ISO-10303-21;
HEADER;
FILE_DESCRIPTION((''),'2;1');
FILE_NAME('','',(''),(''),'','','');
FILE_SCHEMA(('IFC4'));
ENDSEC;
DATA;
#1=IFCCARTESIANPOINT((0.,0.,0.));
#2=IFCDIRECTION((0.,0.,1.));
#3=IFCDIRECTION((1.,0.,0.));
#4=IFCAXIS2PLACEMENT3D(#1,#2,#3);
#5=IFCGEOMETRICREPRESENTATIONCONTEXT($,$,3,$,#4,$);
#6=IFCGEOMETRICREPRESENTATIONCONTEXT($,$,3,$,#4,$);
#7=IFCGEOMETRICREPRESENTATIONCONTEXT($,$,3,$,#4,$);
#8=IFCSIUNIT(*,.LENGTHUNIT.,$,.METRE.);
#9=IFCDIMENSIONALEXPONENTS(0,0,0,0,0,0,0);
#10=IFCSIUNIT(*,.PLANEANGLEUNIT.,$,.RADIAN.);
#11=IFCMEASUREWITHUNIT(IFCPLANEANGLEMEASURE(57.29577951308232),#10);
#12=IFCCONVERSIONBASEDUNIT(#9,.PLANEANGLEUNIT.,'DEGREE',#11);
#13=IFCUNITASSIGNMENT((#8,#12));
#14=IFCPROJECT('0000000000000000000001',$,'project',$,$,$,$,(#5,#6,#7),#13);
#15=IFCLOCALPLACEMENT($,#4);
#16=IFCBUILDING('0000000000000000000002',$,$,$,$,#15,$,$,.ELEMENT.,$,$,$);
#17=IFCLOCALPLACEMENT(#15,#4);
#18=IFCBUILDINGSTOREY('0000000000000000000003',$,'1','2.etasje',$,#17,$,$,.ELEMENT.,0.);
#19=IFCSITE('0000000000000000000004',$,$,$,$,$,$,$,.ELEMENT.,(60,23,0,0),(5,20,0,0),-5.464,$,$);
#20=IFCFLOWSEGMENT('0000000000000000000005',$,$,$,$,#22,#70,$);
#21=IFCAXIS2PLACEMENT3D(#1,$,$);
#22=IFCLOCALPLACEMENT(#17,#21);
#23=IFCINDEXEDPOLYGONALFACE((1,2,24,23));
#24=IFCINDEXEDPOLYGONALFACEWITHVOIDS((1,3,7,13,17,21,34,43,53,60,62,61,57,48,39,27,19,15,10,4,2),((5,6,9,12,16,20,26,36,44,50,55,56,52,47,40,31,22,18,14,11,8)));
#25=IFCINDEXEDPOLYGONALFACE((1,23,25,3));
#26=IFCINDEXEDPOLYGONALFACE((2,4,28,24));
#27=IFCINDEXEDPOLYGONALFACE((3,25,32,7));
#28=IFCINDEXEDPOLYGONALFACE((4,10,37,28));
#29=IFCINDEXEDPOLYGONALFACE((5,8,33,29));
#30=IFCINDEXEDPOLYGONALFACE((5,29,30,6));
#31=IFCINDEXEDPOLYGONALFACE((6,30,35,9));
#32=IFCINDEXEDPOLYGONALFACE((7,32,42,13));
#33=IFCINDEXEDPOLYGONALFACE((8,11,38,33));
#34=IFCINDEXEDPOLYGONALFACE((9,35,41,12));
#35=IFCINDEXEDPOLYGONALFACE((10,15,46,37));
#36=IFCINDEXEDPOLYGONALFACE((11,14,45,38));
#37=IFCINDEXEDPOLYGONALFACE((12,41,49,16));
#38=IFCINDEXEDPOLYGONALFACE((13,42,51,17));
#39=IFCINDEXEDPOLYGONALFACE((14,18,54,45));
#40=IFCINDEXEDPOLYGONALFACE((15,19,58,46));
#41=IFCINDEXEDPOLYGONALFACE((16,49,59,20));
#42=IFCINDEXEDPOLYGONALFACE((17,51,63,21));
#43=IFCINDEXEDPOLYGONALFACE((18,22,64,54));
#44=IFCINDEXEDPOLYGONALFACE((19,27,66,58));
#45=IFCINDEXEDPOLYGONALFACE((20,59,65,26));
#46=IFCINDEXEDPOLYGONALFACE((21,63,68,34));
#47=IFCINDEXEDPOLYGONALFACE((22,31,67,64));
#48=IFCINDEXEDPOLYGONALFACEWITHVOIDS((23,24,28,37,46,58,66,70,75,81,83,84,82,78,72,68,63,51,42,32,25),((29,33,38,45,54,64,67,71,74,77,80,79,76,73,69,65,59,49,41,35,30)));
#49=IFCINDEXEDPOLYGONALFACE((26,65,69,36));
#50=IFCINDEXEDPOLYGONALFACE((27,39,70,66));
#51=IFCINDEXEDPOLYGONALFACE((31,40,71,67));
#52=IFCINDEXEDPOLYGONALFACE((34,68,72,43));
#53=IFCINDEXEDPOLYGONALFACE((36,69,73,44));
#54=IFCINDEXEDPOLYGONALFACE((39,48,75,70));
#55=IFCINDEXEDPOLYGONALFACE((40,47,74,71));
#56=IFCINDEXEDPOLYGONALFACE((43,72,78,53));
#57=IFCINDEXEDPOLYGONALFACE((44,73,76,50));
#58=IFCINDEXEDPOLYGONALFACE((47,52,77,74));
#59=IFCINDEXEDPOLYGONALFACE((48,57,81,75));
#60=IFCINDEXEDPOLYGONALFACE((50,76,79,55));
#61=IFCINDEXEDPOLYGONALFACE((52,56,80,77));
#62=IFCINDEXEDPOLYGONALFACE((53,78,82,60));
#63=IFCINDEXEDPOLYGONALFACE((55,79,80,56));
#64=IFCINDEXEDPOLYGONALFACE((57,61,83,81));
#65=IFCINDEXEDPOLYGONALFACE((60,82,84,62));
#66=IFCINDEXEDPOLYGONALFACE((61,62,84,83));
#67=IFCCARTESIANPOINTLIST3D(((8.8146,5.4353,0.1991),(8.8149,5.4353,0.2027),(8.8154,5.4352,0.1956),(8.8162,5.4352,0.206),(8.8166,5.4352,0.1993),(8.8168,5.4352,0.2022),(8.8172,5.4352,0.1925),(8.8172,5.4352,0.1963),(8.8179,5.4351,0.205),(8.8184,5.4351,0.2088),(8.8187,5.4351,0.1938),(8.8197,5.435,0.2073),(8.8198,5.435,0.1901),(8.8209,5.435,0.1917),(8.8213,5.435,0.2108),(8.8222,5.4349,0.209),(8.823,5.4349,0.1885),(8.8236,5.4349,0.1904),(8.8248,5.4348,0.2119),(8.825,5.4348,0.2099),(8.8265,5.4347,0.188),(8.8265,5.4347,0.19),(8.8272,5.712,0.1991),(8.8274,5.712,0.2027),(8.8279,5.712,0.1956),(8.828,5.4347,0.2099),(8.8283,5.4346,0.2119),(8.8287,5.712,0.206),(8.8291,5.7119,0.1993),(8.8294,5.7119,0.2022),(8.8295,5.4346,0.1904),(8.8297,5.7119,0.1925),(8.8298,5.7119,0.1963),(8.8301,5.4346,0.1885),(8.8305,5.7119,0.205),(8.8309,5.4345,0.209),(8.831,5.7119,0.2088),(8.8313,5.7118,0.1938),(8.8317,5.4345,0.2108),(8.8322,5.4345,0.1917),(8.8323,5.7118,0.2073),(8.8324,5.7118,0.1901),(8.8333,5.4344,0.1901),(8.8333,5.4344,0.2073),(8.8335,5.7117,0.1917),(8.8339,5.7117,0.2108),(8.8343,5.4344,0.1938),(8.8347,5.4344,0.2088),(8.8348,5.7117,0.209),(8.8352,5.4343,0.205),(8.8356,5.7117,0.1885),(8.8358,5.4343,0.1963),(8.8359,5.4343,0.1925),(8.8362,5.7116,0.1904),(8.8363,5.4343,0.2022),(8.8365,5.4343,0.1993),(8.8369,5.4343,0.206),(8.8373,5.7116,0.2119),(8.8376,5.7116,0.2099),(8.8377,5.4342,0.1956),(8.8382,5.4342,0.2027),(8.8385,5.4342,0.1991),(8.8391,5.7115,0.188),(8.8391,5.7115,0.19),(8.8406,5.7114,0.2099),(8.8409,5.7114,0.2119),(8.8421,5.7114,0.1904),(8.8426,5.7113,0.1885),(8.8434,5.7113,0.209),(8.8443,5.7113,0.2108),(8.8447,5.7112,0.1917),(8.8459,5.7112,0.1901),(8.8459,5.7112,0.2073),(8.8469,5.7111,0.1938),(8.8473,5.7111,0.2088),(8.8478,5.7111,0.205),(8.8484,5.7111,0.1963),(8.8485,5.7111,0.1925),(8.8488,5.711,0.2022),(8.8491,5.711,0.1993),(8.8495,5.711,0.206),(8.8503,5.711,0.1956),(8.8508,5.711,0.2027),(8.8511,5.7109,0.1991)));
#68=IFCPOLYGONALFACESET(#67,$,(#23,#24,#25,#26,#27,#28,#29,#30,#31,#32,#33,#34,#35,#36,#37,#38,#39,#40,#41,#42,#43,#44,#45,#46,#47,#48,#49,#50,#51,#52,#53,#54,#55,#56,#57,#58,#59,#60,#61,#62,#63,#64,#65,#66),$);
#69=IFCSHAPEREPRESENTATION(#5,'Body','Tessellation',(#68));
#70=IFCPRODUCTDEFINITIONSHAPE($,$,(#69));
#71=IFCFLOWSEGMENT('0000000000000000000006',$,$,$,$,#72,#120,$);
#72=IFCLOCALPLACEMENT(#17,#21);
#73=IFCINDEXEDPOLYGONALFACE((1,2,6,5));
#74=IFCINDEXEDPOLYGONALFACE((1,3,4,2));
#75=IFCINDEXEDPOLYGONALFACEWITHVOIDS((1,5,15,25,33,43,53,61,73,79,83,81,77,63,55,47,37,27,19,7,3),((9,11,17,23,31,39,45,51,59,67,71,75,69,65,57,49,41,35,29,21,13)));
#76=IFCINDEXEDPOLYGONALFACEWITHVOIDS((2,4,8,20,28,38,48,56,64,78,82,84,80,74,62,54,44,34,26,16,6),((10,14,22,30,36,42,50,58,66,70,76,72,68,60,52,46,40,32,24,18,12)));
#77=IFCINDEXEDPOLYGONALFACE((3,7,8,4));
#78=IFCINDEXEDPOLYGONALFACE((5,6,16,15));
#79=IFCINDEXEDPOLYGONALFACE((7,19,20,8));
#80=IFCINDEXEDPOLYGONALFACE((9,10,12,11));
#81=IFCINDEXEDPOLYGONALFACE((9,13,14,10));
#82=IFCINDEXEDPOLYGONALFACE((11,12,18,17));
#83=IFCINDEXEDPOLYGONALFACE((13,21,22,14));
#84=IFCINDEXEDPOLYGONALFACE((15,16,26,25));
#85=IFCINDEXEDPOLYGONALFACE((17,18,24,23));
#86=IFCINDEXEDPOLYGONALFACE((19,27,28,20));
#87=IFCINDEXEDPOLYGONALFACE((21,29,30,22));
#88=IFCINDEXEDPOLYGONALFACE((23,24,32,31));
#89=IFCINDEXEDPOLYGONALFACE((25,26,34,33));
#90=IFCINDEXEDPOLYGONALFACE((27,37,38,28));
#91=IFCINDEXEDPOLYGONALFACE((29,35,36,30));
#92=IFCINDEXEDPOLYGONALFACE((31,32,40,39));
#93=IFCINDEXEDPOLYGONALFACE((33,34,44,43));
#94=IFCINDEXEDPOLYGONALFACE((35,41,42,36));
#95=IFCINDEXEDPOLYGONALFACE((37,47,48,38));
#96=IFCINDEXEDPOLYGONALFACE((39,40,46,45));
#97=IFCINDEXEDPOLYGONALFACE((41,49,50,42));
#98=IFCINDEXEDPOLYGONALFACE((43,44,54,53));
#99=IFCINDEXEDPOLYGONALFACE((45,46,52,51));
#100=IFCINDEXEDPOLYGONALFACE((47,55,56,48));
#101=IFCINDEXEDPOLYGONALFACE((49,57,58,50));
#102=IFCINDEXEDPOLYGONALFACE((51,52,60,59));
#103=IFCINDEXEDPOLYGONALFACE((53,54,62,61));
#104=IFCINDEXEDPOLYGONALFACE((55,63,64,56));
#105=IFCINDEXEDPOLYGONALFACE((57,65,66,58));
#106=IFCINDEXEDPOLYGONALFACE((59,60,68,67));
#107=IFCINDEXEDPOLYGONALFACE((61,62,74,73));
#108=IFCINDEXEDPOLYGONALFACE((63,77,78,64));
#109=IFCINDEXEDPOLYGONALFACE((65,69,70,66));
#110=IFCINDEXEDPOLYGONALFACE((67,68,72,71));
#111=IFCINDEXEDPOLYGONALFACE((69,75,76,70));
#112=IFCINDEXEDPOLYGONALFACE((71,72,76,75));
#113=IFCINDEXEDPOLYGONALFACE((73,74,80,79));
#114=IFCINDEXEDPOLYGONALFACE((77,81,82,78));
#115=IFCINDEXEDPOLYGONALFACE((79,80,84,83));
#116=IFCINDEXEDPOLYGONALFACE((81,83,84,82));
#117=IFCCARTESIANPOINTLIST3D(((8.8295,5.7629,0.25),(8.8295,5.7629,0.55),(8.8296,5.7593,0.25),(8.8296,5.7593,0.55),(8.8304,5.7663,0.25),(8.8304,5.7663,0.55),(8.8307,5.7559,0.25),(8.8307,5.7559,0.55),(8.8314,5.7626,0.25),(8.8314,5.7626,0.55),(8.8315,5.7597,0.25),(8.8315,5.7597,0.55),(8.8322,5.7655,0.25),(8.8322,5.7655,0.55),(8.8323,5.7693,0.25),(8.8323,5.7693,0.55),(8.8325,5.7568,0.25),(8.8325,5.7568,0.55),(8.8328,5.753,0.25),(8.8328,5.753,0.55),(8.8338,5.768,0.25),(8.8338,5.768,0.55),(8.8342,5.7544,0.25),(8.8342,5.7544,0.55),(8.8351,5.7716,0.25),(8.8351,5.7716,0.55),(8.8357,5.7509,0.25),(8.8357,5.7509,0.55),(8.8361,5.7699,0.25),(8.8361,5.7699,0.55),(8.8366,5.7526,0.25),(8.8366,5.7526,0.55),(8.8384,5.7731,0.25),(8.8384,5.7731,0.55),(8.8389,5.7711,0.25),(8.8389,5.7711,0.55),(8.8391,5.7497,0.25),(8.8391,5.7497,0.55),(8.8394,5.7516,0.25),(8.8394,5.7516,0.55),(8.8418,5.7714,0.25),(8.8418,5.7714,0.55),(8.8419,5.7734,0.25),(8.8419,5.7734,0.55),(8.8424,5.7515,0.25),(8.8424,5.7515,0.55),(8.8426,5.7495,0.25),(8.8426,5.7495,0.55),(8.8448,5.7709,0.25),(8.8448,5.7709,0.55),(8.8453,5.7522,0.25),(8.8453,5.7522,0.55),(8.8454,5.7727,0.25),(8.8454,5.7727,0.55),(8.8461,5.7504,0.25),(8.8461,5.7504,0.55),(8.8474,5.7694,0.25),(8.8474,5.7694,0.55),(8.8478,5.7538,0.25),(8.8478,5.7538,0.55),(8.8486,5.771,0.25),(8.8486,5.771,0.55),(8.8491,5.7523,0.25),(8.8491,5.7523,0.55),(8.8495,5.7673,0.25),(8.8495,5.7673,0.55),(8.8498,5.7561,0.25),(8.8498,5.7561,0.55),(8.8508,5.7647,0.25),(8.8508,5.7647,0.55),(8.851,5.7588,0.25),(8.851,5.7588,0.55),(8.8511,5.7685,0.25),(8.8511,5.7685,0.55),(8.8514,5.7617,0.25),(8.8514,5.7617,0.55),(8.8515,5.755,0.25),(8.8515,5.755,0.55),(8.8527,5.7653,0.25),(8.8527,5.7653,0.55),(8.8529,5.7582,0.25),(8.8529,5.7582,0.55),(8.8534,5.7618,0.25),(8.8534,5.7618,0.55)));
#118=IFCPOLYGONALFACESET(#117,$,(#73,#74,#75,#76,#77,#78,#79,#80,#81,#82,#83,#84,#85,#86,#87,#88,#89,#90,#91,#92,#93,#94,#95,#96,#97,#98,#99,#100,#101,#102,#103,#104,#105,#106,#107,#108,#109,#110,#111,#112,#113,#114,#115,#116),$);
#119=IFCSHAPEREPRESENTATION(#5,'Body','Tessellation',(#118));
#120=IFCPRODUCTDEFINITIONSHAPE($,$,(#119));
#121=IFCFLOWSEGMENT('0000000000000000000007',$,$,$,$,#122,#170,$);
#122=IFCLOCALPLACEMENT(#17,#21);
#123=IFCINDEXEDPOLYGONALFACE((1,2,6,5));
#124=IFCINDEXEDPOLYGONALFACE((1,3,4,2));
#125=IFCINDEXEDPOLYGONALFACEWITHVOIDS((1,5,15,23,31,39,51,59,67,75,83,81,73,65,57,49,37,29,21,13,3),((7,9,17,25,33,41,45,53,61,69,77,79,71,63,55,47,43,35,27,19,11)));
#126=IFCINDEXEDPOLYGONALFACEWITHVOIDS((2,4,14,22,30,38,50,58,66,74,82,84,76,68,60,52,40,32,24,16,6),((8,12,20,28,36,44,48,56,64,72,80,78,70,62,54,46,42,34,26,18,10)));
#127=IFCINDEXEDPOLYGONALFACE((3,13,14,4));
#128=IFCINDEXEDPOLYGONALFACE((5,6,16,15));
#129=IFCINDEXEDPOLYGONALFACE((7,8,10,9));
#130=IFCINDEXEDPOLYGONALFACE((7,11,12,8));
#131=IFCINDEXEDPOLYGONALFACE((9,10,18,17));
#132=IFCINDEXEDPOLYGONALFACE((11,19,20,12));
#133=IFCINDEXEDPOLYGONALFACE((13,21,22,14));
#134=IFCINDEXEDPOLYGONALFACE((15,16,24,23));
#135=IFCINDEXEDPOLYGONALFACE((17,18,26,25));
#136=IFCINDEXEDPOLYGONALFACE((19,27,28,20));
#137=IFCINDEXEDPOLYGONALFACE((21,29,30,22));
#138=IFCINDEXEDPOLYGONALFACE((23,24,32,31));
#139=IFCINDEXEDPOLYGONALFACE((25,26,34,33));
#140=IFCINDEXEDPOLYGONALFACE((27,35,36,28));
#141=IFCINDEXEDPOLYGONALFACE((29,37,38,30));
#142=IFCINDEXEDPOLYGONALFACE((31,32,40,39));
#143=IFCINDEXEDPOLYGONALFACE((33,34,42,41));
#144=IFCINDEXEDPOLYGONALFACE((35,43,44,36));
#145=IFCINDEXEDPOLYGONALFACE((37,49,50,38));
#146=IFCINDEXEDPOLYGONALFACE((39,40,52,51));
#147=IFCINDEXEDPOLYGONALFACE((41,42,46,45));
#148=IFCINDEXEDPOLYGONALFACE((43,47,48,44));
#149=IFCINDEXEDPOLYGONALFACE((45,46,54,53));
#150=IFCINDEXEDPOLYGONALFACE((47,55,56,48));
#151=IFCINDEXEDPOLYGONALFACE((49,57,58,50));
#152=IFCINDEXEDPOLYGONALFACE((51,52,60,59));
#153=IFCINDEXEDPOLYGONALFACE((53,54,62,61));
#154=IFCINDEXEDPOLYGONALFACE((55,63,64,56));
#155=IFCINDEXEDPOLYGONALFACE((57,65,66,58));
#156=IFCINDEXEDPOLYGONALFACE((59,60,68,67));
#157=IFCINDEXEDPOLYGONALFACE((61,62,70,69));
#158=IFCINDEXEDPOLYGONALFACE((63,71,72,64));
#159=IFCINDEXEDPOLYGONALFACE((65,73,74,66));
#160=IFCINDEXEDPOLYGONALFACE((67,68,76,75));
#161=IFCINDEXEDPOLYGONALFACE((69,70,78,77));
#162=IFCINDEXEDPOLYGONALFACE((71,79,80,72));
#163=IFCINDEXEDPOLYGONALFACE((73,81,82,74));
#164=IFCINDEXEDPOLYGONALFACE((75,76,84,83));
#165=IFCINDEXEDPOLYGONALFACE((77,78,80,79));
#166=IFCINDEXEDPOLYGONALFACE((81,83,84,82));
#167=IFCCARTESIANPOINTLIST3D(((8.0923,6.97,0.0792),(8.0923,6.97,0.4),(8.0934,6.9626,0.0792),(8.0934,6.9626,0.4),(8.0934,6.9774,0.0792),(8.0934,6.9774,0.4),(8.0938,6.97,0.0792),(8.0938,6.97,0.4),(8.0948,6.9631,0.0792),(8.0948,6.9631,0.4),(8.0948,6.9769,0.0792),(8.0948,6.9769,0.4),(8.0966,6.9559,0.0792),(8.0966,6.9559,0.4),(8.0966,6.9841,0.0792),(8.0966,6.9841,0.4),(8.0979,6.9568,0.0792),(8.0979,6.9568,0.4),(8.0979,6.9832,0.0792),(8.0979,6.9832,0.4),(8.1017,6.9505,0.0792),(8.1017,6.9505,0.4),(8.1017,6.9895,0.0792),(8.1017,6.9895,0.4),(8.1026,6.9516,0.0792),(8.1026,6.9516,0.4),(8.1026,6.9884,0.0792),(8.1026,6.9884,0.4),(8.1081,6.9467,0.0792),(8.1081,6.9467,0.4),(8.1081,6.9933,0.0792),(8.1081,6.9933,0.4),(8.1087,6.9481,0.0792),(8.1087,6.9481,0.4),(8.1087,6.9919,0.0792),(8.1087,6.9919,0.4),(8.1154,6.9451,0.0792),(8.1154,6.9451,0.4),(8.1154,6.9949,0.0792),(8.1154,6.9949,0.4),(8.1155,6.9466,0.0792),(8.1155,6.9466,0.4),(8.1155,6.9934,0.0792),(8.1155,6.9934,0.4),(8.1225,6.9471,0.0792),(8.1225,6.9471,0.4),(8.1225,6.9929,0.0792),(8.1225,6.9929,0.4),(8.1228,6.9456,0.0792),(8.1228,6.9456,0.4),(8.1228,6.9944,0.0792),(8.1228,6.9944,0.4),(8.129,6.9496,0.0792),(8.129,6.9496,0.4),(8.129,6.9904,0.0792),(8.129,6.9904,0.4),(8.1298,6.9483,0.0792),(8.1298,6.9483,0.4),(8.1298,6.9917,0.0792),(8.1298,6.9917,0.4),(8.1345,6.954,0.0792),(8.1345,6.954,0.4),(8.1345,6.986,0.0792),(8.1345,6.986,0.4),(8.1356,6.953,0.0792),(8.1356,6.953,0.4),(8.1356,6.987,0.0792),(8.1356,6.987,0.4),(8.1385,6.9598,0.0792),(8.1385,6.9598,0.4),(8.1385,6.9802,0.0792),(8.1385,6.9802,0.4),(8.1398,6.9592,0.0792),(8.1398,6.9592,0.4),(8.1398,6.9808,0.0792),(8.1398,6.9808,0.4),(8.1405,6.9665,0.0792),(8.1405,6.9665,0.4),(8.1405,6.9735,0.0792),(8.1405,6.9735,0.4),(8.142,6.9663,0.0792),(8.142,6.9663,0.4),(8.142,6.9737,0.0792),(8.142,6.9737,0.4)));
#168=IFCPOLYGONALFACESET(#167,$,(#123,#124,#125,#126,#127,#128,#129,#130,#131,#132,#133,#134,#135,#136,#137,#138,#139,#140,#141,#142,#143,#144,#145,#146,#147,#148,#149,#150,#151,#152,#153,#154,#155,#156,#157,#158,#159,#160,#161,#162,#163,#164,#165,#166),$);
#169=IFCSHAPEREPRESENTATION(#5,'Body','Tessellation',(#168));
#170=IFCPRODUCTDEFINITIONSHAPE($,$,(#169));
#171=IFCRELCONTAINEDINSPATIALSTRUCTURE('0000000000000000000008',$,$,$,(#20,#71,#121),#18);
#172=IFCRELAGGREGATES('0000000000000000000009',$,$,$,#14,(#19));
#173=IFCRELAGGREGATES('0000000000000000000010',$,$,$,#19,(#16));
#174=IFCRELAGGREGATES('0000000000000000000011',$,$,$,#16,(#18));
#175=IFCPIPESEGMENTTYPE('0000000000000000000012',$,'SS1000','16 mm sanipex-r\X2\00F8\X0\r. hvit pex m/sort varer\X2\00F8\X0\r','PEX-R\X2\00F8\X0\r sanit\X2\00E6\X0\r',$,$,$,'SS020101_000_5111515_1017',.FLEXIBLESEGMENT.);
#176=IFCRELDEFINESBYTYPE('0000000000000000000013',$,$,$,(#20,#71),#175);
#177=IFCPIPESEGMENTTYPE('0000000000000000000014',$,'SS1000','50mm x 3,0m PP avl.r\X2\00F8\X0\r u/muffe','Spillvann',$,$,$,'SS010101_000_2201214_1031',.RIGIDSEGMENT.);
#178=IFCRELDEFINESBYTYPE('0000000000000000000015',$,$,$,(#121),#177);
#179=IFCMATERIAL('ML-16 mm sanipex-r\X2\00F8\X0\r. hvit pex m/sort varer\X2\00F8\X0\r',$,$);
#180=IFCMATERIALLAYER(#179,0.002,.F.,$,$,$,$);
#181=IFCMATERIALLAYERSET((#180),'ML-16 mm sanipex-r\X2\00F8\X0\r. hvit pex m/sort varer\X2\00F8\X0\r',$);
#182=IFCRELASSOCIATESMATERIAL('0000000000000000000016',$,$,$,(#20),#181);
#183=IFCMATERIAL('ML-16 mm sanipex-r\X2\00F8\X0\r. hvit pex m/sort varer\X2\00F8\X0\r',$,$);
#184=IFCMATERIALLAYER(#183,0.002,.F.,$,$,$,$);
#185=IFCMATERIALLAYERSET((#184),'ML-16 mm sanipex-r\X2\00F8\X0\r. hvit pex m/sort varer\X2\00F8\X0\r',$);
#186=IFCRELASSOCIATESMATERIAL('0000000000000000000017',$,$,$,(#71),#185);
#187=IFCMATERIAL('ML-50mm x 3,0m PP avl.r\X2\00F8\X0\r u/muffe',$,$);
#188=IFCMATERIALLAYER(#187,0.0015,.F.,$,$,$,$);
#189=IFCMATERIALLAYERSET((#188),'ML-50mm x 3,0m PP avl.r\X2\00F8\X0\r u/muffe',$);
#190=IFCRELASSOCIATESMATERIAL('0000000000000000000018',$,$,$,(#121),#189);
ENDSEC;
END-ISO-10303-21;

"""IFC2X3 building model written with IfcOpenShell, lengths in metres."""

from ifc_helpers import new_model, entity, si_unit, converted_unit, frame, origin_with_axes, origin_2d_with_axis, place, context, project, spatial, hollow_circle, extrude, material, layer, layer_set, layer_usage, type_object, element, save


model = new_model("IFC2X3")

# Units and contexts
context_of_model_1 = context(None, 3, world=origin_with_axes())
context_of_model_2 = context(None, 3, world=origin_with_axes())
context_of_model_3 = context(None, 3, world=origin_with_axes())
ifc_project = project(units=[si_unit("LENGTHUNIT", "METRE"), converted_unit("PLANEANGLEUNIT", "DEGREE", entity("IfcPlaneAngleMeasure", 57.29577951308232), si_unit("PLANEANGLEUNIT", "RADIAN"), dimensions=[0, 0, 0, 0, 0, 0, 0])], contexts=[context_of_model_1, context_of_model_2, context_of_model_3])

# Site, building, storey
site = spatial("IfcSite", under=ifc_project, CompositionType="ELEMENT", RefLatitude=(60, 23, 0, 0), RefLongitude=(5, 20, 0, 0), RefElevation=-5.464)
building_placement = place(None, origin_with_axes())
building = spatial("IfcBuilding", under=site, at=building_placement, CompositionType="ELEMENT")
storey_placement = place(building_placement, origin_with_axes())
storey = spatial("IfcBuildingStorey", under=building, at=storey_placement, Name="1", Description="2.etasje", CompositionType="ELEMENT", Elevation=0.0)

# Flow segments
pipe_segment_type_1 = type_object("IfcPipeSegmentType", Name="SS1000", Description="16 mm sanipex-rør. hvit pex m/sort varerør", ApplicableOccurrence="PEX-Rør sanitær", ElementType="SS020101_000_5111515_1017", PredefinedType="FLEXIBLESEGMENT")
ifc_material_1 = material(Name="ML-16 mm sanipex-rør. hvit pex m/sort varerør")
ifc_layer_1 = layer(ifc_material_1, 0.002, ventilated=False)
ifc_layer_set_1 = layer_set([ifc_layer_1], Name="ML-16 mm sanipex-rør. hvit pex m/sort varerør")
ifc_layer_usage_1 = layer_usage(ifc_layer_set_1, "AXIS2", "POSITIVE", 0.0)
flow_segment_1_placement = place(storey_placement, frame((8.8265, 5.4347, 0.2), z_axis=(0.045369, 0.99897, 0.0), x_axis=(0.0, 0.0, -1.0)))
element("IfcFlowSegment", 1, at=flow_segment_1_placement, inside=storey, type_object=pipe_segment_type_1, material=ifc_layer_usage_1, context=context_of_model_1, shape_type="SweptSolid", body=[
    extrude(hollow_circle(Radius=0.012, WallThickness=0.002, at=origin_2d_with_axis()), origin_with_axes(), (0.0, 0.0, 1.0), 0.277),
])
ifc_material_2 = material(Name="ML-16 mm sanipex-rør. hvit pex m/sort varerør")
ifc_layer_2 = layer(ifc_material_2, 0.002, ventilated=False)
ifc_layer_set_2 = layer_set([ifc_layer_2], Name="ML-16 mm sanipex-rør. hvit pex m/sort varerør")
ifc_layer_usage_2 = layer_usage(ifc_layer_set_2, "AXIS2", "POSITIVE", 0.0)
flow_segment_2_placement = place(storey_placement, frame((8.8414, 5.7614, 0.25), z_axis=(0.0, 0.0, 1.0), x_axis=(0.045369, 0.99897, 0.0)))
element("IfcFlowSegment", 2, at=flow_segment_2_placement, inside=storey, type_object=pipe_segment_type_1, material=ifc_layer_usage_2, context=context_of_model_1, shape_type="SweptSolid", body=[
    extrude(hollow_circle(Radius=0.012, WallThickness=0.002, at=origin_2d_with_axis()), origin_with_axes(), (0.0, 0.0, 1.0), 0.3),
])
ifc_material_3 = material(Name="ML-50mm x 3,0m PP avl.rør u/muffe")
ifc_layer_3 = layer(ifc_material_3, 0.0015, ventilated=False)
ifc_layer_set_3 = layer_set([ifc_layer_3], Name="ML-50mm x 3,0m PP avl.rør u/muffe")
ifc_layer_usage_3 = layer_usage(ifc_layer_set_3, "AXIS2", "POSITIVE", 0.0)
pipe_segment_type_2 = type_object("IfcPipeSegmentType", Name="SS1000", Description="50mm x 3,0m PP avl.rør u/muffe", ApplicableOccurrence="Spillvann", ElementType="SS010101_000_2201214_1031", PredefinedType="RIGIDSEGMENT")
flow_segment_3_placement = place(storey_placement, frame((8.1173, 6.97, 0.4), z_axis=(0.0, 0.0, -1.0), x_axis=(-1.0, 0.0, 0.0)))
element("IfcFlowSegment", 3, at=flow_segment_3_placement, inside=storey, type_object=pipe_segment_type_2, material=ifc_layer_usage_3, context=context_of_model_1, shape_type="SweptSolid", body=[
    extrude(hollow_circle(Radius=0.025, WallThickness=0.0015, at=origin_2d_with_axis()), origin_with_axes(), (0.0, 0.0, 1.0), 0.3208),
])

save(model, "model.ifc")
